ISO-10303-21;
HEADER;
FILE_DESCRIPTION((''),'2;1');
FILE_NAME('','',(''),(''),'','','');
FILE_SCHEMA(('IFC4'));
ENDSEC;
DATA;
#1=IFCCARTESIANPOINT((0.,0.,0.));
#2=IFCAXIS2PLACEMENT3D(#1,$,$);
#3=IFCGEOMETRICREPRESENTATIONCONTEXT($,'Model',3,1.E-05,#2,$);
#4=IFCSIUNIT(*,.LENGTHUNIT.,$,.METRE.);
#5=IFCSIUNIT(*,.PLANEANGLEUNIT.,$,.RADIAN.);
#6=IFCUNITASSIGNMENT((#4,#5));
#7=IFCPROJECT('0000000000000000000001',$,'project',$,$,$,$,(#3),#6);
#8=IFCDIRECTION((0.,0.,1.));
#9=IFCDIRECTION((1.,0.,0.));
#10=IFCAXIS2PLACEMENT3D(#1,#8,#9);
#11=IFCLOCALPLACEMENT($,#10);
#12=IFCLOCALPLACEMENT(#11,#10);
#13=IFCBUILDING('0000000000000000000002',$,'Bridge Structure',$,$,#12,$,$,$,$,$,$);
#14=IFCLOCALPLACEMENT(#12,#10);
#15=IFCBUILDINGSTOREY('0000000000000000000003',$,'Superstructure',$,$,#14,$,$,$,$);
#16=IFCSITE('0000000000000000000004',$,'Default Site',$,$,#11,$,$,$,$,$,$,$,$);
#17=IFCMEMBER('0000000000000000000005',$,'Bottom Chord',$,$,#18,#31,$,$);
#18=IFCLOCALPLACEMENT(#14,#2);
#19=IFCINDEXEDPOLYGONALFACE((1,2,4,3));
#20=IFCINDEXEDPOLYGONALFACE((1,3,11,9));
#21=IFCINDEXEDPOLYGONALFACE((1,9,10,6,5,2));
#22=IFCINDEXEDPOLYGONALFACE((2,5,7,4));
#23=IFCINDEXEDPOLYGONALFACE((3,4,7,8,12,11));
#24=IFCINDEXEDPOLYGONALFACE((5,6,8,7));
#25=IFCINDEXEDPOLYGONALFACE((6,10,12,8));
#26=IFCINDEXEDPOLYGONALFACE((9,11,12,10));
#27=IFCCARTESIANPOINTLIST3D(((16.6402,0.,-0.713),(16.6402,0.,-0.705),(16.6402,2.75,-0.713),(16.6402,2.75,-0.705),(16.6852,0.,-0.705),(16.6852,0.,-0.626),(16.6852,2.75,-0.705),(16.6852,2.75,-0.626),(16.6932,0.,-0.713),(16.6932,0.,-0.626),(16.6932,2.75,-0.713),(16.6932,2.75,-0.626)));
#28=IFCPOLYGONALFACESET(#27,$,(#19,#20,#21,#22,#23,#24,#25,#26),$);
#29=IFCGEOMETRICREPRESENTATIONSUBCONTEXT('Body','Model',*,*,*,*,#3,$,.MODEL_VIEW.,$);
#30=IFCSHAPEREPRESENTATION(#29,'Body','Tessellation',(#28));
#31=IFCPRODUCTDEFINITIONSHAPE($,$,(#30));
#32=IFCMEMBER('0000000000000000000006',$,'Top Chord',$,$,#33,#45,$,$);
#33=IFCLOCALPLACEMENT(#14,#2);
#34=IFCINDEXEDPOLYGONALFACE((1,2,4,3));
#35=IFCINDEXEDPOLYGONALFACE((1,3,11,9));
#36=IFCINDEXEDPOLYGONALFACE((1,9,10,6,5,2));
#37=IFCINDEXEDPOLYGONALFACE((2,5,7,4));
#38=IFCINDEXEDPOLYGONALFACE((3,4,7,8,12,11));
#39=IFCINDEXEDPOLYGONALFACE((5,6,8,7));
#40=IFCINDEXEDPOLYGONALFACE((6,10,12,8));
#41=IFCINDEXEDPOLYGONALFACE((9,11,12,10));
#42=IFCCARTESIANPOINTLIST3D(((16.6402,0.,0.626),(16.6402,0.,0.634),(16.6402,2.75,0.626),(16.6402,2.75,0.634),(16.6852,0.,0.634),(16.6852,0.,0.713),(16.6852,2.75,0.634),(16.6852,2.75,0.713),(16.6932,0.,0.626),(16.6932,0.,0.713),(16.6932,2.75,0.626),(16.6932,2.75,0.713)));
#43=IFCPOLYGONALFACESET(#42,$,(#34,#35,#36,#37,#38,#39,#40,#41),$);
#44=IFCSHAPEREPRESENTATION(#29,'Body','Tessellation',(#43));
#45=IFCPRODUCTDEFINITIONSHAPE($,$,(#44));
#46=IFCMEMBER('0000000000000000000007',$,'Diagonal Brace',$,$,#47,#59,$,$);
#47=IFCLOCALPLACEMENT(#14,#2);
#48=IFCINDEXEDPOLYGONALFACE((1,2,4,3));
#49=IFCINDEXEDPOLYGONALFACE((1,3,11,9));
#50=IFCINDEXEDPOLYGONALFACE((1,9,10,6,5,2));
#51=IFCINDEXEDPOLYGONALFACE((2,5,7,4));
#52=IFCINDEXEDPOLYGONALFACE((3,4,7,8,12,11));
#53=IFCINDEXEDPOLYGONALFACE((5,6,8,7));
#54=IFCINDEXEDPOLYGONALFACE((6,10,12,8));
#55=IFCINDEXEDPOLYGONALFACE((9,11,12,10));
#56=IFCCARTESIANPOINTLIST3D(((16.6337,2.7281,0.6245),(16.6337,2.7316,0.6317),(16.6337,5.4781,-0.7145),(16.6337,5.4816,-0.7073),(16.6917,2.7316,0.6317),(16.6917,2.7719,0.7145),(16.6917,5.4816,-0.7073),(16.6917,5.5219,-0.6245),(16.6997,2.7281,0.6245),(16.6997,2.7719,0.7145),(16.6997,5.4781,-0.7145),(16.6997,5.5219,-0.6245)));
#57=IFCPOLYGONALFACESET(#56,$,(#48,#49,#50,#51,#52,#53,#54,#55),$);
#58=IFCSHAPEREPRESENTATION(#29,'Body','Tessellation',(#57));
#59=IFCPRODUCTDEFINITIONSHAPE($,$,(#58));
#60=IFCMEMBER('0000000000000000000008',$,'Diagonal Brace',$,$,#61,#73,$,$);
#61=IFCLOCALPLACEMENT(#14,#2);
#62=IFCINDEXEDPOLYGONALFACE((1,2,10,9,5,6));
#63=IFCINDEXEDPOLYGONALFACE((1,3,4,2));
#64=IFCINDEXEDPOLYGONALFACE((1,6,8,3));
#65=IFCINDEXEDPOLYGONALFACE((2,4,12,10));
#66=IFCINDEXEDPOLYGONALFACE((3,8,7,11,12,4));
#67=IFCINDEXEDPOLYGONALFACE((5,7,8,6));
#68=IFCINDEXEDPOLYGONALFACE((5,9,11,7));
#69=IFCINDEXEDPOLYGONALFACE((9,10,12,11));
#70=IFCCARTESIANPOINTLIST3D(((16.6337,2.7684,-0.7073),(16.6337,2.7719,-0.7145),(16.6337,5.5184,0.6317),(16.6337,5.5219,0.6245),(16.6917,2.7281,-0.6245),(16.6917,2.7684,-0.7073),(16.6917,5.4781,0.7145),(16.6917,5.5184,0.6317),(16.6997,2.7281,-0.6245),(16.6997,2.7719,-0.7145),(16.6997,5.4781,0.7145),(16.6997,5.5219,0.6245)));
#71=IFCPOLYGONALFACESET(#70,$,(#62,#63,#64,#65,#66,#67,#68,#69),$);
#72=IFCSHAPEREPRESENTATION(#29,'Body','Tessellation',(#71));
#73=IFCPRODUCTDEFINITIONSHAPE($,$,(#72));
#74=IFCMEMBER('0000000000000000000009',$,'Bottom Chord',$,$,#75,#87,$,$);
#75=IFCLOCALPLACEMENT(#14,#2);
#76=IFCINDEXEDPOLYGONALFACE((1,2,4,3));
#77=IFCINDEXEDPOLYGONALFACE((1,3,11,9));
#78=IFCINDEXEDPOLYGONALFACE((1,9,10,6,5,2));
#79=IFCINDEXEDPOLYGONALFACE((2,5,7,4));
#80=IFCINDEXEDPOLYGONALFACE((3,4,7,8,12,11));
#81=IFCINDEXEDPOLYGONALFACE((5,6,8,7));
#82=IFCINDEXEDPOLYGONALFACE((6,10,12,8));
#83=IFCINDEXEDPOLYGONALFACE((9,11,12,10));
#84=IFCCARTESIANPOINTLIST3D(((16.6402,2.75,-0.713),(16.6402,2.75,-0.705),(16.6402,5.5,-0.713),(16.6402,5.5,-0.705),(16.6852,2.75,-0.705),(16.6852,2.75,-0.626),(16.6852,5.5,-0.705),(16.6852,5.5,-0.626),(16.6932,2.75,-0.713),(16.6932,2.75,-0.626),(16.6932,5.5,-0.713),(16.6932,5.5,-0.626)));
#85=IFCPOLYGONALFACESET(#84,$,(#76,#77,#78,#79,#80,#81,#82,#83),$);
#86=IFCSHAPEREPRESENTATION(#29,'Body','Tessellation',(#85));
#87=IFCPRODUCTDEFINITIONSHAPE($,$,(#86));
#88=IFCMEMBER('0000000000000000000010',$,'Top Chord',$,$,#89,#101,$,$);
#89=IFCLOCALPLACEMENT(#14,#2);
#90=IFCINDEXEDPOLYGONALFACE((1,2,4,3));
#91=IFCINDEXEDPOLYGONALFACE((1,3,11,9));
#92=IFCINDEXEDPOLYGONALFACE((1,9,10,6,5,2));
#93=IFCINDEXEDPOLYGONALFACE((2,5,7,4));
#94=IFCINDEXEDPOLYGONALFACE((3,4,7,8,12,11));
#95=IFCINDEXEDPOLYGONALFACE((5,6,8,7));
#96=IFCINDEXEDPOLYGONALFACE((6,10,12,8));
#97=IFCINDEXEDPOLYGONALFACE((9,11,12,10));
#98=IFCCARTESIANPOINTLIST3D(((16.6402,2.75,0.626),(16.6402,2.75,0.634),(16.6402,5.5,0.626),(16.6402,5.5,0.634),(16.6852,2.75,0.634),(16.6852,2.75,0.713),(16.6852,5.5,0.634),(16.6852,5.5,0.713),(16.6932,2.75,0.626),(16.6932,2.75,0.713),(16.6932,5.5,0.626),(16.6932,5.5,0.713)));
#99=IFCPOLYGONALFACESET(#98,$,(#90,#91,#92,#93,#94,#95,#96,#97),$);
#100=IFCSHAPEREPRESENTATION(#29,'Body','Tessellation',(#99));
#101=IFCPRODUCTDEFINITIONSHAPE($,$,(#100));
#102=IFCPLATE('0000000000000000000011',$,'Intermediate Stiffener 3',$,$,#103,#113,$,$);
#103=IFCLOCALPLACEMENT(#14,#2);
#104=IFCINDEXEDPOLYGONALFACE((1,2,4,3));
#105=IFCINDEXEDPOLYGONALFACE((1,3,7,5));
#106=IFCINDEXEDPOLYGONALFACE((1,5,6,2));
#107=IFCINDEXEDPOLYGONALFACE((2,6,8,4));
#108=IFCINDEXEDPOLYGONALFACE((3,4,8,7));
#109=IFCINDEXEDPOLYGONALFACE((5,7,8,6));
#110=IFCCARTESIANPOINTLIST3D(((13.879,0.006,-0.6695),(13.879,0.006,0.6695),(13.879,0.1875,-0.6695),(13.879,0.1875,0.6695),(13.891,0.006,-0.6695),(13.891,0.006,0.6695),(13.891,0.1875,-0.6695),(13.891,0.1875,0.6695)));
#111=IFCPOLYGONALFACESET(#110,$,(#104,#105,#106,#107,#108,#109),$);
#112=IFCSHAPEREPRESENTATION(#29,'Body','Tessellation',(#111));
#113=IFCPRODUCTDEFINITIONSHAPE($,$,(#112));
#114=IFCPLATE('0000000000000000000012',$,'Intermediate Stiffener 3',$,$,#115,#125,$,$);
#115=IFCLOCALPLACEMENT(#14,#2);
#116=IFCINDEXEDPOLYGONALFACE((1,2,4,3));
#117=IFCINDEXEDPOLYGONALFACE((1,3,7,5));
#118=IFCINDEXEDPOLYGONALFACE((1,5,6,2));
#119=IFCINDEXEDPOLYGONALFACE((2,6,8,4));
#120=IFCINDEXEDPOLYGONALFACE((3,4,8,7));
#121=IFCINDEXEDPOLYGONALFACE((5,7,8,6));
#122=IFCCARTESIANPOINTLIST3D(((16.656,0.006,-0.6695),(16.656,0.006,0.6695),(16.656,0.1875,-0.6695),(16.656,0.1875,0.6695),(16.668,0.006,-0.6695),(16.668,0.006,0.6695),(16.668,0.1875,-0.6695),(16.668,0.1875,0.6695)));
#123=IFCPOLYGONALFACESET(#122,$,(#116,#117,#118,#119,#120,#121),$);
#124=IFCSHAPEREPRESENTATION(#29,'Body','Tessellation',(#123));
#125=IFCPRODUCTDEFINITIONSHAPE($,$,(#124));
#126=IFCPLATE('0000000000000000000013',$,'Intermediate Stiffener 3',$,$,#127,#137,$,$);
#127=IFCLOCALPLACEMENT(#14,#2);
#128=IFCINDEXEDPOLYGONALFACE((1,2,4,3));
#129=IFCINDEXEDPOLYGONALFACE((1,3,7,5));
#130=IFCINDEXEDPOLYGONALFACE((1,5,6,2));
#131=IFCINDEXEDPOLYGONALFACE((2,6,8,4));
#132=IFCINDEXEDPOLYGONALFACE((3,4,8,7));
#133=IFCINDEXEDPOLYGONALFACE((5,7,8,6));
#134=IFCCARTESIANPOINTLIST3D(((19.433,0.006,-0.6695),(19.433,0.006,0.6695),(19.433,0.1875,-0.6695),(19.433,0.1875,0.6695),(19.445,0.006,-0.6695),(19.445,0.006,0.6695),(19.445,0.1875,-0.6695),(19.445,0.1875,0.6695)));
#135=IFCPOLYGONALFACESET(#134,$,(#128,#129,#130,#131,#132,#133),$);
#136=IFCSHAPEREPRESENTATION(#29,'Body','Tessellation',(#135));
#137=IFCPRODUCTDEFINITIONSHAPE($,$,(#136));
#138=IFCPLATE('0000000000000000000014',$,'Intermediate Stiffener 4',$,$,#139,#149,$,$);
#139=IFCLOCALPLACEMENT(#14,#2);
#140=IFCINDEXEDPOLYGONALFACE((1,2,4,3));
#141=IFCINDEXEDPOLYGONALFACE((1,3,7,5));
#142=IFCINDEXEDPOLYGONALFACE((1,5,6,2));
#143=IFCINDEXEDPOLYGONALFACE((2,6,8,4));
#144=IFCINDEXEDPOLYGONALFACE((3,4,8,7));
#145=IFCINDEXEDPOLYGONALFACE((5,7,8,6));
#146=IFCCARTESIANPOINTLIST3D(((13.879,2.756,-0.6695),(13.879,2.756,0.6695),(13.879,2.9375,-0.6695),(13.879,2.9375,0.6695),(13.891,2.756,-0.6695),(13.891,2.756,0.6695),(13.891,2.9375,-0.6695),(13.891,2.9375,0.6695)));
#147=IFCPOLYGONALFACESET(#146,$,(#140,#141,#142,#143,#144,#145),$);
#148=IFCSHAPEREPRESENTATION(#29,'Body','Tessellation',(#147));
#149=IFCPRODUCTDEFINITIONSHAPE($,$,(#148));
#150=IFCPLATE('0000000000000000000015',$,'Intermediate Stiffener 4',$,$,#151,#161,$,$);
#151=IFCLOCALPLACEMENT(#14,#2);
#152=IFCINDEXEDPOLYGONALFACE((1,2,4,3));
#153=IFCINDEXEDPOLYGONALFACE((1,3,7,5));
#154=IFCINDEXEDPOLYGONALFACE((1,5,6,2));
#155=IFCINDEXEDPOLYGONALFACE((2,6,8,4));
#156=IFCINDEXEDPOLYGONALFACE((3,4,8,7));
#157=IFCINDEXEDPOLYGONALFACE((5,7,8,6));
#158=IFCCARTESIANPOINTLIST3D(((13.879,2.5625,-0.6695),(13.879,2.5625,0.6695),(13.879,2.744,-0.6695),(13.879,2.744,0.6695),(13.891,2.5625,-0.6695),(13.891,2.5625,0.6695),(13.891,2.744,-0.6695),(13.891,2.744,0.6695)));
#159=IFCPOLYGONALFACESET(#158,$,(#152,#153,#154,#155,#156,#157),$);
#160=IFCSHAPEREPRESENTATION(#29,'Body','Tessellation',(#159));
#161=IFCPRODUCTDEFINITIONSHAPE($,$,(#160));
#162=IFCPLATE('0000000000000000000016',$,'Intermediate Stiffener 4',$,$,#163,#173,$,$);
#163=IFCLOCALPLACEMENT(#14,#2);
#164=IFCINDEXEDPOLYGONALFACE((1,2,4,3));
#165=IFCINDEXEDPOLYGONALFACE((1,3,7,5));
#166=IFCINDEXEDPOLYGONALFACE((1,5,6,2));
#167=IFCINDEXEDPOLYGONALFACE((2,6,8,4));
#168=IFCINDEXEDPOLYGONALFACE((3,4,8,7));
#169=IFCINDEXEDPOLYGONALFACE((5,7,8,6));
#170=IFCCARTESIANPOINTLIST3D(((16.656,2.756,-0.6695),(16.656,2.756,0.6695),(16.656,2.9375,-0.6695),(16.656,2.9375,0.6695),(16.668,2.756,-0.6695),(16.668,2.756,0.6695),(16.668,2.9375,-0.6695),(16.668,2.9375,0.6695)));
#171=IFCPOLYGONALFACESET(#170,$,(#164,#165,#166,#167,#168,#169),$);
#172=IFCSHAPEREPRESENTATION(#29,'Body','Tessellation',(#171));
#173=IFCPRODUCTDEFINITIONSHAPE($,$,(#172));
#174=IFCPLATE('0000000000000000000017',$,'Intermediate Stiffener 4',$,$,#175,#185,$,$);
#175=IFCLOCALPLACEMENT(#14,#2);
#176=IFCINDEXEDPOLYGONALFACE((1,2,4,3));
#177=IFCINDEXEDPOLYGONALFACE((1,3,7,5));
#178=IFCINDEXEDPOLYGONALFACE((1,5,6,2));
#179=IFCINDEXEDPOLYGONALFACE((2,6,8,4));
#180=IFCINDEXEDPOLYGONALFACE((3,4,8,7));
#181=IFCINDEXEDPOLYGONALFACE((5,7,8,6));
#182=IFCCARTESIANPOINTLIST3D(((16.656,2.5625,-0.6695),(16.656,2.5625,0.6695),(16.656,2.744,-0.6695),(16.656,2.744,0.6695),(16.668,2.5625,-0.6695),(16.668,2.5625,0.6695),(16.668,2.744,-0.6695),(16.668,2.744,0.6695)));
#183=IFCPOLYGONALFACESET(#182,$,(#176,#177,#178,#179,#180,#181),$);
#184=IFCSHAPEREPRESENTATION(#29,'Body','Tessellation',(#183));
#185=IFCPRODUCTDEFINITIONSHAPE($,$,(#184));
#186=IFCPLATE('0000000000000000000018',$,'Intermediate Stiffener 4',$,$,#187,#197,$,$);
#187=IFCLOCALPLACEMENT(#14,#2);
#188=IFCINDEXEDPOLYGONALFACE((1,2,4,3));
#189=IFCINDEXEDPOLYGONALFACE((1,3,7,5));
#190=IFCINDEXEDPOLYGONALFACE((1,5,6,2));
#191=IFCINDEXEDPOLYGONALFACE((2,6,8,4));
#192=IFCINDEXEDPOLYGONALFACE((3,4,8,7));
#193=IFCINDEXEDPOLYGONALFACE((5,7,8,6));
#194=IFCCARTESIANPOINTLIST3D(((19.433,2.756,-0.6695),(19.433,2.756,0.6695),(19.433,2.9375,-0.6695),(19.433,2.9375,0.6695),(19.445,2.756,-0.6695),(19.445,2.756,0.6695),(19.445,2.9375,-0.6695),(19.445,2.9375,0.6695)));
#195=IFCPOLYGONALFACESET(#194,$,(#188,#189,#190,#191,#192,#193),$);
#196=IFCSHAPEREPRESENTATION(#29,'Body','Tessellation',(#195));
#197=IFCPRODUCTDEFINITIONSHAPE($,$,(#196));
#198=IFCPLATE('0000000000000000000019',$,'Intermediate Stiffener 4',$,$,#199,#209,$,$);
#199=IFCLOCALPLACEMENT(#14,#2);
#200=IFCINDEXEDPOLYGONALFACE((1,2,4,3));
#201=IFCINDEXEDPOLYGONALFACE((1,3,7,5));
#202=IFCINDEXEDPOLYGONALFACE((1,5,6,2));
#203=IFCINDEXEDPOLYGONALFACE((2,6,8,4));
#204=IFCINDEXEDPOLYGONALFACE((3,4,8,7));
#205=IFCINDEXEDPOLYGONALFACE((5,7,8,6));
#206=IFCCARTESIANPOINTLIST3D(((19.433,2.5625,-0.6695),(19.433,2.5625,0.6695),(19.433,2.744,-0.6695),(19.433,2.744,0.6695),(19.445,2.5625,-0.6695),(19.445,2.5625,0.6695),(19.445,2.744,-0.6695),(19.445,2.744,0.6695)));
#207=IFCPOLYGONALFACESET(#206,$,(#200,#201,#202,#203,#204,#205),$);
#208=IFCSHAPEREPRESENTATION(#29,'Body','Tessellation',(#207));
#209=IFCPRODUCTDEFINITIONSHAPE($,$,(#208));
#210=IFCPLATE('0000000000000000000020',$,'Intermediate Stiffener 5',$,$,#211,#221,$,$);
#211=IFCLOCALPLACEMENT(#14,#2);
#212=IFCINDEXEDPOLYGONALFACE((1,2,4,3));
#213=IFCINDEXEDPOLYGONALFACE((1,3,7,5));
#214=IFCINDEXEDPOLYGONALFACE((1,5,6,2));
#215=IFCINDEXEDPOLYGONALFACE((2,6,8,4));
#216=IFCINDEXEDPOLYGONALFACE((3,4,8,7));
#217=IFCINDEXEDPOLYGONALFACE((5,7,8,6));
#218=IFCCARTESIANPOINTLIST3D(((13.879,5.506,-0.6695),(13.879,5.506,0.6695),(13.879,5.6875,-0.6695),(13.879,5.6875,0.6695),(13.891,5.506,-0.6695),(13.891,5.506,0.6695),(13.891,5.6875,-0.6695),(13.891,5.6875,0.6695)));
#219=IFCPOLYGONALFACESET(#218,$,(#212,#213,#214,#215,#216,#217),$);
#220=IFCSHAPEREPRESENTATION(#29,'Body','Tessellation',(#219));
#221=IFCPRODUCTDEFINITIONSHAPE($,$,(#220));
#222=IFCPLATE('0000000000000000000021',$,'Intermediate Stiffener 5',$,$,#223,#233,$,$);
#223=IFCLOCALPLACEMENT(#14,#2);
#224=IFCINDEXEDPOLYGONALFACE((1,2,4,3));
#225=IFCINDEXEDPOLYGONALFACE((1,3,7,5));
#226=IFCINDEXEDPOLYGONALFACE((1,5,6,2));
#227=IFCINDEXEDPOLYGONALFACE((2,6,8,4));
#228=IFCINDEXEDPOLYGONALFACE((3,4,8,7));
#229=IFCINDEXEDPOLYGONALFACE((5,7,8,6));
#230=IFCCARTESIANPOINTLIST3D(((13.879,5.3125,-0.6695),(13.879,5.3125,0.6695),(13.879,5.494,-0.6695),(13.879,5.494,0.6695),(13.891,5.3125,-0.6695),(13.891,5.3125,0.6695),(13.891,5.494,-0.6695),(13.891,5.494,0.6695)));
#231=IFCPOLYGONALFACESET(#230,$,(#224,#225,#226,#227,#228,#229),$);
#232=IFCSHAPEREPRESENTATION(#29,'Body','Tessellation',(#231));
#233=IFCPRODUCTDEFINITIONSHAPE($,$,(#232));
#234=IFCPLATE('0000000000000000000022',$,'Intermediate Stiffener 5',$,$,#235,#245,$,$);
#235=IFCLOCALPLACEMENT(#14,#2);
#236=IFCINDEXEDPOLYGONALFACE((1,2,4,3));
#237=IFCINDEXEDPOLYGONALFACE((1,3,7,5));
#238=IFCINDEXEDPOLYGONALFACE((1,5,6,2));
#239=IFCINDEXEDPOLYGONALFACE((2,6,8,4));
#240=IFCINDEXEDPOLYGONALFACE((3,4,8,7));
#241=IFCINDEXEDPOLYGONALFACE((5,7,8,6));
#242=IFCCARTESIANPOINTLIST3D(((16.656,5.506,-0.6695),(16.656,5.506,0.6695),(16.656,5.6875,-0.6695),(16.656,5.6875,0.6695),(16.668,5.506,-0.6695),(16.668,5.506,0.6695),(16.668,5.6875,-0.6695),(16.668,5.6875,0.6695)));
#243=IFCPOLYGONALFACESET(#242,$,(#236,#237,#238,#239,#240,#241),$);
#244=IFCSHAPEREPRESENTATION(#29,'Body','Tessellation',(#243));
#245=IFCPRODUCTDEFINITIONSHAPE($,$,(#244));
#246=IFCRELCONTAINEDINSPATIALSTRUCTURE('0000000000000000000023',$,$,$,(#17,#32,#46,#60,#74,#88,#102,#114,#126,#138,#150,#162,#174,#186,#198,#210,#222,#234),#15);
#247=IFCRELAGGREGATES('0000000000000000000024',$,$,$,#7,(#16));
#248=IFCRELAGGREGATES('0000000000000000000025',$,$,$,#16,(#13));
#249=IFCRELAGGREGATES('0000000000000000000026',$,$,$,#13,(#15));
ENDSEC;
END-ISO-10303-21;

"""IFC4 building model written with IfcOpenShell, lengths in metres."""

from ifc_helpers import new_model, si_unit, frame, origin, origin_with_axes, origin_2d_with_axis, place, context, subcontext, project, spatial, rectangle, l_section, extrude, element, save


model = new_model("IFC4")

# Units and contexts
model_context = context("Model", 3, precision=1e-05, world=origin())
body_context = subcontext(model_context, "Body", "Model", "MODEL_VIEW")
ifc_project = project(units=[si_unit("LENGTHUNIT", "METRE"), si_unit("PLANEANGLEUNIT", "RADIAN")], contexts=[model_context])

# Site, building, storey
site_placement = place(None, origin_with_axes())
site = spatial("IfcSite", under=ifc_project, at=site_placement, Name="Default Site")
building_placement = place(site_placement, origin_with_axes())
building = spatial("IfcBuilding", under=site, at=building_placement, Name="Bridge Structure")
storey_placement = place(building_placement, origin_with_axes())
storey = spatial("IfcBuildingStorey", under=building, at=storey_placement, Name="Superstructure")

# Members
for number, where, z_axis, x_axis, name in (
    (1, (16.6667, 0.0, -0.6695), (0.0, 1.0, 0.0), (-1.0, 0.0, 0.0), "Bottom Chord"),
    (2, (16.6667, 0.0, 0.6695), (0.0, 1.0, 0.0), (-1.0, 0.0, 0.0), "Top Chord"),
):
    element("IfcMember", number, at=place(storey_placement, frame(where, z_axis=z_axis, x_axis=x_axis)), inside=storey, Name=name, context=body_context, shape_type="SweptSolid", body=[
        extrude(l_section(Depth=0.087, Width=0.053, Thickness=0.008, at=origin_2d_with_axis()), origin_with_axes(), (0.0, 0.0, 1.0), 2.75),
    ])
for number, where, z_axis, x_axis, name in (
    (3, (16.6667, 2.75, 0.6695), (0.0, 0.899086, -0.437773), (-1.0, 0.0, 0.0), "Diagonal Brace"),
    (4, (16.6667, 2.75, -0.6695), (0.0, 0.899086, 0.437773), (-1.0, 0.0, 0.0), "Diagonal Brace"),
):
    element("IfcMember", number, at=place(storey_placement, frame(where, z_axis=z_axis, x_axis=x_axis)), inside=storey, Name=name, context=body_context, shape_type="SweptSolid", body=[
        extrude(l_section(Depth=0.1, Width=0.066, Thickness=0.008, at=origin_2d_with_axis()), origin_with_axes(), (0.0, 0.0, 1.0), 3.0587),
    ])
for number, where, z_axis, x_axis, name in (
    (5, (16.6667, 2.75, -0.6695), (0.0, 1.0, 0.0), (-1.0, 0.0, 0.0), "Bottom Chord"),
    (6, (16.6667, 2.75, 0.6695), (0.0, 1.0, 0.0), (-1.0, 0.0, 0.0), "Top Chord"),
):
    element("IfcMember", number, at=place(storey_placement, frame(where, z_axis=z_axis, x_axis=x_axis)), inside=storey, Name=name, context=body_context, shape_type="SweptSolid", body=[
        extrude(l_section(Depth=0.087, Width=0.053, Thickness=0.008, at=origin_2d_with_axis()), origin_with_axes(), (0.0, 0.0, 1.0), 2.75),
    ])

# Plates
for number, where, z_axis, x_axis, name in (
    (7, (13.885, 0.0968, -0.6695), (0.0, 0.0, 1.0), (1.0, 0.0, 0.0), "Intermediate Stiffener 3"),
    (8, (16.662, 0.0968, -0.6695), (0.0, 0.0, 1.0), (1.0, 0.0, 0.0), "Intermediate Stiffener 3"),
    (9, (19.439, 0.0968, -0.6695), (0.0, 0.0, 1.0), (1.0, 0.0, 0.0), "Intermediate Stiffener 3"),
    (10, (13.885, 2.8468, -0.6695), (0.0, 0.0, 1.0), (1.0, 0.0, 0.0), "Intermediate Stiffener 4"),
    (11, (13.885, 2.6532, -0.6695), (0.0, 0.0, 1.0), (1.0, 0.0, 0.0), "Intermediate Stiffener 4"),
    (12, (16.662, 2.8468, -0.6695), (0.0, 0.0, 1.0), (1.0, 0.0, 0.0), "Intermediate Stiffener 4"),
    (13, (16.662, 2.6532, -0.6695), (0.0, 0.0, 1.0), (1.0, 0.0, 0.0), "Intermediate Stiffener 4"),
    (14, (19.439, 2.8468, -0.6695), (0.0, 0.0, 1.0), (1.0, 0.0, 0.0), "Intermediate Stiffener 4"),
    (15, (19.439, 2.6532, -0.6695), (0.0, 0.0, 1.0), (1.0, 0.0, 0.0), "Intermediate Stiffener 4"),
    (16, (13.885, 5.5968, -0.6695), (0.0, 0.0, 1.0), (1.0, 0.0, 0.0), "Intermediate Stiffener 5"),
    (17, (13.885, 5.4032, -0.6695), (0.0, 0.0, 1.0), (1.0, 0.0, 0.0), "Intermediate Stiffener 5"),
    (18, (16.662, 5.5968, -0.6695), (0.0, 0.0, 1.0), (1.0, 0.0, 0.0), "Intermediate Stiffener 5"),
):
    element("IfcPlate", number, at=place(storey_placement, frame(where, z_axis=z_axis, x_axis=x_axis)), inside=storey, Name=name, context=body_context, shape_type="SweptSolid", body=[
        extrude(rectangle(XDim=0.012, YDim=0.1815, at=origin_2d_with_axis()), origin_with_axes(), (0.0, 0.0, 1.0), 1.339),
    ])

save(model, "model.ifc")
